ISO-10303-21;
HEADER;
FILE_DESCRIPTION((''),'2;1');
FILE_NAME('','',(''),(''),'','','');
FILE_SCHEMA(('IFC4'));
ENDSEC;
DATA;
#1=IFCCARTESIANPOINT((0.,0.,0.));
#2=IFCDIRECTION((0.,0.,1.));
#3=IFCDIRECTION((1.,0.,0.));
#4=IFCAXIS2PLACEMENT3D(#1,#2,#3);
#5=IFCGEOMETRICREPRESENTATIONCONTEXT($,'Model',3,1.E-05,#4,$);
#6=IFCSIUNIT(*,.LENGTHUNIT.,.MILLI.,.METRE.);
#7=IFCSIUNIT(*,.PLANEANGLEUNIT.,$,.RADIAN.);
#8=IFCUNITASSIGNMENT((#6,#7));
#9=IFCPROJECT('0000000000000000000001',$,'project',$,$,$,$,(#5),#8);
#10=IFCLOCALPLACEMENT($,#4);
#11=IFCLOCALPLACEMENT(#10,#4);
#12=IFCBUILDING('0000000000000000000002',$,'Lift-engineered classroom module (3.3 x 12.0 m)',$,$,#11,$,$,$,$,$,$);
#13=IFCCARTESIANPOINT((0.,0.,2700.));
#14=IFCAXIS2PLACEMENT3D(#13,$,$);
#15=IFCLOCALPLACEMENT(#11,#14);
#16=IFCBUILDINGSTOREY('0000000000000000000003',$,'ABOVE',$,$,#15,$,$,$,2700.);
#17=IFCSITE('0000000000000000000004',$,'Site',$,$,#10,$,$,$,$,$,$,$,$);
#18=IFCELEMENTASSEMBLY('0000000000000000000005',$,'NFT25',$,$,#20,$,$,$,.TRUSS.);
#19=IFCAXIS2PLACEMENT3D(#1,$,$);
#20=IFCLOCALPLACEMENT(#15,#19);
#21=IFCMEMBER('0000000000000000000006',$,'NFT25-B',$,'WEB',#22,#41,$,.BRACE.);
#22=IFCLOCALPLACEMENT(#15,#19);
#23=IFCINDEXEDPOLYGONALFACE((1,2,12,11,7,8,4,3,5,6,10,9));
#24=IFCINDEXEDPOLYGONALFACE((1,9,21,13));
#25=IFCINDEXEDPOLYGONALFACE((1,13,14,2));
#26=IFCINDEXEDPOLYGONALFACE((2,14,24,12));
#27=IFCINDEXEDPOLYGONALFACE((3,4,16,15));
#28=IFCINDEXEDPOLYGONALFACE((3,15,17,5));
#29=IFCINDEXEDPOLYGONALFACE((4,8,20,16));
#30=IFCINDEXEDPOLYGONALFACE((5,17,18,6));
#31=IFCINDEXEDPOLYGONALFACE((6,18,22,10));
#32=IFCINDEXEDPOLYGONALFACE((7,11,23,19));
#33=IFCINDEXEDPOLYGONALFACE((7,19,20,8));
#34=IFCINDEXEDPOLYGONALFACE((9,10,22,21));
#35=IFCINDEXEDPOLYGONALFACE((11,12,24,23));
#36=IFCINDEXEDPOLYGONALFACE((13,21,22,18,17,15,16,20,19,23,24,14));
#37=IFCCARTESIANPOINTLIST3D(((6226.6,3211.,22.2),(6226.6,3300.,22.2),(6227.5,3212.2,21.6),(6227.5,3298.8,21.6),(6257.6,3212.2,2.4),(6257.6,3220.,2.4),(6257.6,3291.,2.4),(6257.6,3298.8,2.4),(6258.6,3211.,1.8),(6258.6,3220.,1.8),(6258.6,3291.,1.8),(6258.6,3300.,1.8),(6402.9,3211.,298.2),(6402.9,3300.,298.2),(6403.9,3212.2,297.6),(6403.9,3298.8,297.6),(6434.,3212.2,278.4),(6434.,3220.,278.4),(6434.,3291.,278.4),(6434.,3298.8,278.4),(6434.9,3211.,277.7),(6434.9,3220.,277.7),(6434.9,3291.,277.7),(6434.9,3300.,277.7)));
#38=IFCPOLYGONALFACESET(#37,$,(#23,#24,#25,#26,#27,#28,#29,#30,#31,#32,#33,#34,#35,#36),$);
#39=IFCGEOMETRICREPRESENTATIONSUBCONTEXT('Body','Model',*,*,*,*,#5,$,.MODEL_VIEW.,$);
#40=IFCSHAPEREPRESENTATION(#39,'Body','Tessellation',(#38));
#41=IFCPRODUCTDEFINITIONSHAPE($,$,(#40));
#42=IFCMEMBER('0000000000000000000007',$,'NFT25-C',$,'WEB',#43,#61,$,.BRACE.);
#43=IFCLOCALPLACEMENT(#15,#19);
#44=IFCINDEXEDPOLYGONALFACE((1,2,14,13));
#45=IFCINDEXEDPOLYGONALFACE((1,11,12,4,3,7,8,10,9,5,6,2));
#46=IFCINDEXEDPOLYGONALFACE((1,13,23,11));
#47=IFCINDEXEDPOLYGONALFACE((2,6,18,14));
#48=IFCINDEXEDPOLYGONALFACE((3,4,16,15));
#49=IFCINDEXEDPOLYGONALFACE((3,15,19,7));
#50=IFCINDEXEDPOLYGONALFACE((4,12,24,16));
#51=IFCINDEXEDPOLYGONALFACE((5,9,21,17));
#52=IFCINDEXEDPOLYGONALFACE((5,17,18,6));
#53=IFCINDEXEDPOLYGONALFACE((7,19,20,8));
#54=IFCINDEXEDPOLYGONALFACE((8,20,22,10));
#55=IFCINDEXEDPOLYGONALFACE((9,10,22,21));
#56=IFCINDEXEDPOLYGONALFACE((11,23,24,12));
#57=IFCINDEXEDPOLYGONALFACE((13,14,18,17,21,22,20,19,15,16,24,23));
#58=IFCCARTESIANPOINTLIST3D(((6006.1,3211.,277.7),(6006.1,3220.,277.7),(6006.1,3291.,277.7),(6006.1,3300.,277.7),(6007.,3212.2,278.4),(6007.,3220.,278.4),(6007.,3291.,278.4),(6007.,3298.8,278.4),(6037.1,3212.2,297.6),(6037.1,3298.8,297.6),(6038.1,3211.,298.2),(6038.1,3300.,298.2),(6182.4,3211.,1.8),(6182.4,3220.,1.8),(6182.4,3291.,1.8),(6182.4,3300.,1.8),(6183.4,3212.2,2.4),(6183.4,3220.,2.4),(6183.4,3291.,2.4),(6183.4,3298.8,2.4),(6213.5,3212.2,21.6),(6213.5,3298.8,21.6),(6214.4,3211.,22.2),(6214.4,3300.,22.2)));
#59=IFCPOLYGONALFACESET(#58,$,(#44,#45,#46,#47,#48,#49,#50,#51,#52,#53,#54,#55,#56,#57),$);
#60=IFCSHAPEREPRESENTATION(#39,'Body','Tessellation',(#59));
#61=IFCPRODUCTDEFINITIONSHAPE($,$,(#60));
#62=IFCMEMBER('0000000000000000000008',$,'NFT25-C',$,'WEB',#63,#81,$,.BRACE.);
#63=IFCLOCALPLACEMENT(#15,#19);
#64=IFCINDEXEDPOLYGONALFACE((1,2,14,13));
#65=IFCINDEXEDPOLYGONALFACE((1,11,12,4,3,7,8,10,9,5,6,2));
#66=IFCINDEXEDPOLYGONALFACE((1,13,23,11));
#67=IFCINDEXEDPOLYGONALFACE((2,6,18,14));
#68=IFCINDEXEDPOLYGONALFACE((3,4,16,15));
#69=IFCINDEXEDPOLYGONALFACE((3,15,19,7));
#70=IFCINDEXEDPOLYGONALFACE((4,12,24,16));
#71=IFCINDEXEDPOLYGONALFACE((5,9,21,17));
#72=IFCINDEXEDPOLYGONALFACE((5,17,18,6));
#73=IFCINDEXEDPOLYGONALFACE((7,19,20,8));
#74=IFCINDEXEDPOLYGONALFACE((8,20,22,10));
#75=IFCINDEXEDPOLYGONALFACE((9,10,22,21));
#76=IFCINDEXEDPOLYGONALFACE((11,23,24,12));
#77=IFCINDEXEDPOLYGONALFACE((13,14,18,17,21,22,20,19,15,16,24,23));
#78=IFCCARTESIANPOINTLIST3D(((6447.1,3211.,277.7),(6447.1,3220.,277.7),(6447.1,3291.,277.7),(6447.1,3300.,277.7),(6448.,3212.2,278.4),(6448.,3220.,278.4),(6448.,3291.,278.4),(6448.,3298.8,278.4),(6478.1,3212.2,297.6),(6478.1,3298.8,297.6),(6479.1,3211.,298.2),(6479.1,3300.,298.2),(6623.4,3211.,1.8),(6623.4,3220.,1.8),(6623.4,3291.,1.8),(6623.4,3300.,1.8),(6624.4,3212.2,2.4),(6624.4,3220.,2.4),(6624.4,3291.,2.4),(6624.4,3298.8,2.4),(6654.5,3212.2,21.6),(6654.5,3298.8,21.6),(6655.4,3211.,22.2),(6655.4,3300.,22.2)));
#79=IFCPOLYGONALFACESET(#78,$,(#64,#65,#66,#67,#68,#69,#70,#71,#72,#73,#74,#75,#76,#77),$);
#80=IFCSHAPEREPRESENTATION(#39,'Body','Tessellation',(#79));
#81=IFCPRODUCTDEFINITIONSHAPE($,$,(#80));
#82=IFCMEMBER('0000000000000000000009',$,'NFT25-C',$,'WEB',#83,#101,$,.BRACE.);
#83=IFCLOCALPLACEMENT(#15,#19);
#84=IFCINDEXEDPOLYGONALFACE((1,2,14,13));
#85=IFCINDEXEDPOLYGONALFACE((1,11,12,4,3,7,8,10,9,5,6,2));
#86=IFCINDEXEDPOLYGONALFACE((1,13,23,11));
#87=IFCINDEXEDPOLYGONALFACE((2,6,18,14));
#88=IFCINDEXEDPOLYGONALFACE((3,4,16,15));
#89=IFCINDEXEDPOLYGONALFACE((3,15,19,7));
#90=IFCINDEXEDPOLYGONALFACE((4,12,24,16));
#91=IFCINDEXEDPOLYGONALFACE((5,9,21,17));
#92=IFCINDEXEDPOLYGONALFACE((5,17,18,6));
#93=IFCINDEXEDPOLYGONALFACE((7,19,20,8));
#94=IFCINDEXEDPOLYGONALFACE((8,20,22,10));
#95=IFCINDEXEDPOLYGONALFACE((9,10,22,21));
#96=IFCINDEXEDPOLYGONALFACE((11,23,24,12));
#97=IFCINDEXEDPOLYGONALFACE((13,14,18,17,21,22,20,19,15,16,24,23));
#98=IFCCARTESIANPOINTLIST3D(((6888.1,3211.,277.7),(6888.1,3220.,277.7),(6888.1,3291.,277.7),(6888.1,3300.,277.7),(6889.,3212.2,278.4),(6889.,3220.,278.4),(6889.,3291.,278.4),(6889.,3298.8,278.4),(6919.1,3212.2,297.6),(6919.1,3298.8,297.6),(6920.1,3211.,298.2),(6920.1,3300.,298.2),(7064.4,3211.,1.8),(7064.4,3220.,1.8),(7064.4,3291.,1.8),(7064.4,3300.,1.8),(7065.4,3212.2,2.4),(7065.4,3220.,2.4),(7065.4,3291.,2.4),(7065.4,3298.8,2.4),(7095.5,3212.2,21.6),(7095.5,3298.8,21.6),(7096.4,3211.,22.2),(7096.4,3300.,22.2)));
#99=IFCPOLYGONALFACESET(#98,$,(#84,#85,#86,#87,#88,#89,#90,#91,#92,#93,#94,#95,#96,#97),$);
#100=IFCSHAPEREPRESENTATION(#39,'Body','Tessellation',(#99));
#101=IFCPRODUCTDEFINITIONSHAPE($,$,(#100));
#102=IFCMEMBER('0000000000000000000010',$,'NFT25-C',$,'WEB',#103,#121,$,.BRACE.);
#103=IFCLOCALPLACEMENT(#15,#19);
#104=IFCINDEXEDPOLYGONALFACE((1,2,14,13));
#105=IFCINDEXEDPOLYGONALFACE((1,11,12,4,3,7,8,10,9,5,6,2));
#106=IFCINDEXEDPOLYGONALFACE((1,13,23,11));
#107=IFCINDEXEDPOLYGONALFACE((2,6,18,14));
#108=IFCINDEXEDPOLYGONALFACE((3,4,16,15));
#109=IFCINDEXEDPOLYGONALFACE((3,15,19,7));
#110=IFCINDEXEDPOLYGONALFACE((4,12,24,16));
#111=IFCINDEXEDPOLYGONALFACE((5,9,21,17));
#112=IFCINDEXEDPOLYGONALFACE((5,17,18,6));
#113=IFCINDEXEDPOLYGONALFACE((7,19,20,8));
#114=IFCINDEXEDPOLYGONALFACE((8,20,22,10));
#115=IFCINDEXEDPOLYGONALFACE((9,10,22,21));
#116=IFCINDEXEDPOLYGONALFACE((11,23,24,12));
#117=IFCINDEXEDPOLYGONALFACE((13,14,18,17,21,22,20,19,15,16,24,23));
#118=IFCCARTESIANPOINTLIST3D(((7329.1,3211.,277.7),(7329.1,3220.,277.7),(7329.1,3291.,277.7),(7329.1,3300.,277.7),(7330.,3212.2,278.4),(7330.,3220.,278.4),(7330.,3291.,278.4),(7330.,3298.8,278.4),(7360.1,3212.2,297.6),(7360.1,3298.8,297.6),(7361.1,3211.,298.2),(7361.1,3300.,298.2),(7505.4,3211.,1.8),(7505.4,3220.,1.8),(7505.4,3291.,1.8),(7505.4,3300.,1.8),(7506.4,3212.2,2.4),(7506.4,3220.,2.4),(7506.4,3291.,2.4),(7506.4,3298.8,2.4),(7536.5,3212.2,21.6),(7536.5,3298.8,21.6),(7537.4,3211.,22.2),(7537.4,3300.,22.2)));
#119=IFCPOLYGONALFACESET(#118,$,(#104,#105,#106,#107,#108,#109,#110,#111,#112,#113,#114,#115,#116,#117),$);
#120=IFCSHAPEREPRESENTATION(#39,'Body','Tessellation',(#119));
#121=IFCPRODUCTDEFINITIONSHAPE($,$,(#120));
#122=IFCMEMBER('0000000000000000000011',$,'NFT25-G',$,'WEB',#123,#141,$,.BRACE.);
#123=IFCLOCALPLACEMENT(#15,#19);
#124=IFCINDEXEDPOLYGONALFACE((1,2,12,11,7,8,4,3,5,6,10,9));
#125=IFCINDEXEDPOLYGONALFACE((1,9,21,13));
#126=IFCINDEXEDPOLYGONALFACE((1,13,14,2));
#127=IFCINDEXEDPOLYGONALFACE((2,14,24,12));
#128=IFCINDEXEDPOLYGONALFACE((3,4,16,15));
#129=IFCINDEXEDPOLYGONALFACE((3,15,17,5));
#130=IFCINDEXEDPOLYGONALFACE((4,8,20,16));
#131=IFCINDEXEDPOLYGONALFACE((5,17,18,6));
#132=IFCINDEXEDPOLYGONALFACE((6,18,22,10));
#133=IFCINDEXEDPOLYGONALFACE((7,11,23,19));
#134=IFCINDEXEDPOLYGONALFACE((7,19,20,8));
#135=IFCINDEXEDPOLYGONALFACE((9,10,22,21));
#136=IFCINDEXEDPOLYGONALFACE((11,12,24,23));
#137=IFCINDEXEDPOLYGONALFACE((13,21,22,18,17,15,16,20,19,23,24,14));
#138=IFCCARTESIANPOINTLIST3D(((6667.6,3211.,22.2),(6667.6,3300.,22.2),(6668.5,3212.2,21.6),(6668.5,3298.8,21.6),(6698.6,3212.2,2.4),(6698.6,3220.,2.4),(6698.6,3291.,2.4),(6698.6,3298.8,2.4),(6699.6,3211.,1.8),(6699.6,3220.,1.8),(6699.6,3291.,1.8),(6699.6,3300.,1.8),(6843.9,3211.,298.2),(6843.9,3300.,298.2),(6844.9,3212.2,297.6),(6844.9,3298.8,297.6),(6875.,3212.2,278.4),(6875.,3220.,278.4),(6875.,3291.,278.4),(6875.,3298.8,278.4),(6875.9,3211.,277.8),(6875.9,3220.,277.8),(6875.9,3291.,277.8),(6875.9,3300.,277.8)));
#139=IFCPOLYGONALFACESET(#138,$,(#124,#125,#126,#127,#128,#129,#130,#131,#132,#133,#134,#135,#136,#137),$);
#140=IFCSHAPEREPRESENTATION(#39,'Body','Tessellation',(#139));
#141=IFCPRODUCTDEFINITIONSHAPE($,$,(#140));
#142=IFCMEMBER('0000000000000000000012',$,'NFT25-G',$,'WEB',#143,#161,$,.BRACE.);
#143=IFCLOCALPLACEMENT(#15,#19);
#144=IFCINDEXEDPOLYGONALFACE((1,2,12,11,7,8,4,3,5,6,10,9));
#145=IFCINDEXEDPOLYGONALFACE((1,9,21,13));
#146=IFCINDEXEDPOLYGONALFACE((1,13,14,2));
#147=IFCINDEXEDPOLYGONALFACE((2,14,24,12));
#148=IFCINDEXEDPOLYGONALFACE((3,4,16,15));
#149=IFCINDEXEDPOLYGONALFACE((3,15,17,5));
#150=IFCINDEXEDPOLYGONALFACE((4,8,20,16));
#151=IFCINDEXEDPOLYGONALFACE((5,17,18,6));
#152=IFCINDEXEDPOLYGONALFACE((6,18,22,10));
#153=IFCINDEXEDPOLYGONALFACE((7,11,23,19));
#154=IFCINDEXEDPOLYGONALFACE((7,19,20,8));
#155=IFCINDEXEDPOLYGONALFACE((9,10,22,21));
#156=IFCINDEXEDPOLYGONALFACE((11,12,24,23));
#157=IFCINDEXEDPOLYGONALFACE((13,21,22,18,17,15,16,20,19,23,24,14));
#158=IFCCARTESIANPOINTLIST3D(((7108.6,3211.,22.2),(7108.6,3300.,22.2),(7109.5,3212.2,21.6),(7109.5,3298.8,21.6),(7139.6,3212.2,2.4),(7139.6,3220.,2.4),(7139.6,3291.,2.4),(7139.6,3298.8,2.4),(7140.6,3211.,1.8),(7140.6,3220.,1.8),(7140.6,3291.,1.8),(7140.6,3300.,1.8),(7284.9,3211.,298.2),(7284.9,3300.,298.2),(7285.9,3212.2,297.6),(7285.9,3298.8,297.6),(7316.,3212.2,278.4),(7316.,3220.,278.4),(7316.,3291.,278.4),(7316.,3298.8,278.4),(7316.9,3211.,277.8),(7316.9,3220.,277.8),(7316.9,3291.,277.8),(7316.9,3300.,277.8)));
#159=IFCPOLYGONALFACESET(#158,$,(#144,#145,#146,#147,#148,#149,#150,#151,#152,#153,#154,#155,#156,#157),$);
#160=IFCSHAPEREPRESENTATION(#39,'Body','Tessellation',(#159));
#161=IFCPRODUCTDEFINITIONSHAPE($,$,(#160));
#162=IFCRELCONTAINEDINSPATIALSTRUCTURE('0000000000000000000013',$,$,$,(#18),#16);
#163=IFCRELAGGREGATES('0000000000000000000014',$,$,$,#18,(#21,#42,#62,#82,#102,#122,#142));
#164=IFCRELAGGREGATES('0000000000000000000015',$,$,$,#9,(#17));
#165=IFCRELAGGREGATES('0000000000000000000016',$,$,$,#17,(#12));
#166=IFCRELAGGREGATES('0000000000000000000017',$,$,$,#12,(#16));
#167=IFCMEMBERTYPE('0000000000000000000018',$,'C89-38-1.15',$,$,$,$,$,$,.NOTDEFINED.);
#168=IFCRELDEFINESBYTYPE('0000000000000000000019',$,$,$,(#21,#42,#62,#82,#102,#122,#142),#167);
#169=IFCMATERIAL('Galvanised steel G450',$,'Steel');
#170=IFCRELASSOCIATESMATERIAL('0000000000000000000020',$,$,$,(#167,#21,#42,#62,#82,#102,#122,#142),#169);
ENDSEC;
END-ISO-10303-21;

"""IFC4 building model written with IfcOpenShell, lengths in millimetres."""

from ifc_helpers import new_model, si_unit, frame, origin, origin_with_axes, origin_2d, place, context, subcontext, project, spatial, c_section, extrude, material, material_profile, profile_set, profile_usage, type_object, element, aggregate, save


model = new_model("IFC4")

# Units and contexts
model_context = context("Model", 3, precision=1e-05, world=origin_with_axes())
body_context = subcontext(model_context, "Body", "Model", "MODEL_VIEW")
ifc_project = project(units=[si_unit("LENGTHUNIT", "METRE", prefix="MILLI"), si_unit("PLANEANGLEUNIT", "RADIAN")], contexts=[model_context])

# Site, building, storey
site_placement = place(None, origin_with_axes())
site = spatial("IfcSite", under=ifc_project, at=site_placement, Name="Site")
building_placement = place(site_placement, origin_with_axes())
building = spatial("IfcBuilding", under=site, at=building_placement, Name="Lift-engineered classroom module (3.3 x 12.0 m)")
storey_placement = place(building_placement, frame((0.0, 0.0, 2700.0)))
storey = spatial("IfcBuildingStorey", under=building, at=storey_placement, Name="ABOVE", Elevation=2700.0)

# Element assembly, members
ifc_material = material(Name="Galvanised steel G450", Category="Steel")
assembly_1_placement = place(storey_placement, frame((0.0, 3255.5, 0.0)))
assembly_1 = element("IfcElementAssembly", 1, at=assembly_1_placement, inside=storey, Name="NFT25", PredefinedType="TRUSS")
ifc_material_profile_1 = material_profile(ifc_material, c_section(Depth=89.0, Width=38.0, WallThickness=1.1, Girth=9.0, at=origin_2d()), Name="C89-38-1.15")
ifc_profile_set_1 = profile_set([ifc_material_profile_1], Name="C89-38-1.15")
ifc_profile_usage_1 = profile_usage(ifc_profile_set_1)
member_type_1 = type_object("IfcMemberType", Name="C89-38-1.15", PredefinedType="NOTDEFINED", material=ifc_profile_set_1)
member_1_placement = place(assembly_1_placement, frame((6242.6, 0.0, 12.0), z_axis=(0.538459, 0.0, 0.842652), x_axis=(0.842652, 0.0, -0.538459)))
member_1 = element("IfcMember", 2, at=member_1_placement, type_object=member_type_1, material=ifc_profile_usage_1, Name="NFT25-B", ObjectType="WEB", PredefinedType="BRACE", context=body_context, shape_type="SweptSolid", body=[
    extrude(c_section(Depth=89.0, Width=38.0, WallThickness=1.1, Girth=9.0, at=origin_2d()), origin(), (0.0, 0.0, 1.0), 327.5),
])
member_2_placement = place(assembly_1_placement, frame((6198.4, 0.0, 12.0), z_axis=(-0.538459, 0.0, 0.842652), x_axis=(-0.842652, 0.0, -0.538459)))
member_2 = element("IfcMember", 3, at=member_2_placement, type_object=member_type_1, material=ifc_profile_usage_1, Name="NFT25-C", ObjectType="WEB", PredefinedType="BRACE", context=body_context, shape_type="SweptSolid", body=[
    extrude(c_section(Depth=89.0, Width=38.0, WallThickness=1.1, Girth=9.0, at=origin_2d()), origin(), (0.0, 0.0, 1.0), 327.5),
])
member_3_placement = place(assembly_1_placement, frame((6639.4, 0.0, 12.0), z_axis=(-0.538459, 0.0, 0.842652), x_axis=(-0.842652, 0.0, -0.538459)))
member_3 = element("IfcMember", 4, at=member_3_placement, type_object=member_type_1, material=ifc_profile_usage_1, Name="NFT25-C", ObjectType="WEB", PredefinedType="BRACE", context=body_context, shape_type="SweptSolid", body=[
    extrude(c_section(Depth=89.0, Width=38.0, WallThickness=1.1, Girth=9.0, at=origin_2d()), origin(), (0.0, 0.0, 1.0), 327.5),
])
member_4_placement = place(assembly_1_placement, frame((7080.4, 0.0, 12.0), z_axis=(-0.538459, 0.0, 0.842652), x_axis=(-0.842652, 0.0, -0.538459)))
member_4 = element("IfcMember", 5, at=member_4_placement, type_object=member_type_1, material=ifc_profile_usage_1, Name="NFT25-C", ObjectType="WEB", PredefinedType="BRACE", context=body_context, shape_type="SweptSolid", body=[
    extrude(c_section(Depth=89.0, Width=38.0, WallThickness=1.1, Girth=9.0, at=origin_2d()), origin(), (0.0, 0.0, 1.0), 327.5),
])
member_5_placement = place(assembly_1_placement, frame((7521.4, 0.0, 12.0), z_axis=(-0.538459, 0.0, 0.842652), x_axis=(-0.842652, 0.0, -0.538459)))
member_5 = element("IfcMember", 6, at=member_5_placement, type_object=member_type_1, material=ifc_profile_usage_1, Name="NFT25-C", ObjectType="WEB", PredefinedType="BRACE", context=body_context, shape_type="SweptSolid", body=[
    extrude(c_section(Depth=89.0, Width=38.0, WallThickness=1.1, Girth=9.0, at=origin_2d()), origin(), (0.0, 0.0, 1.0), 327.5),
])
member_6_placement = place(assembly_1_placement, frame((6683.6, 0.0, 12.0), z_axis=(0.538437, 0.0, 0.842665), x_axis=(0.842665, 0.0, -0.538437)))
member_6 = element("IfcMember", 7, at=member_6_placement, type_object=member_type_1, material=ifc_profile_usage_1, Name="NFT25-G", ObjectType="WEB", PredefinedType="BRACE", context=body_context, shape_type="SweptSolid", body=[
    extrude(c_section(Depth=89.0, Width=38.0, WallThickness=1.1, Girth=9.0, at=origin_2d()), origin(), (0.0, 0.0, 1.0), 327.5),
])
member_7_placement = place(assembly_1_placement, frame((7124.6, 0.0, 12.0), z_axis=(0.538437, 0.0, 0.842665), x_axis=(0.842665, 0.0, -0.538437)))
member_7 = element("IfcMember", 8, at=member_7_placement, type_object=member_type_1, material=ifc_profile_usage_1, Name="NFT25-G", ObjectType="WEB", PredefinedType="BRACE", context=body_context, shape_type="SweptSolid", body=[
    extrude(c_section(Depth=89.0, Width=38.0, WallThickness=1.1, Girth=9.0, at=origin_2d()), origin(), (0.0, 0.0, 1.0), 327.5),
])
aggregate(assembly_1, [member_1, member_2, member_3, member_4, member_5, member_6, member_7])

save(model, "model.ifc")
